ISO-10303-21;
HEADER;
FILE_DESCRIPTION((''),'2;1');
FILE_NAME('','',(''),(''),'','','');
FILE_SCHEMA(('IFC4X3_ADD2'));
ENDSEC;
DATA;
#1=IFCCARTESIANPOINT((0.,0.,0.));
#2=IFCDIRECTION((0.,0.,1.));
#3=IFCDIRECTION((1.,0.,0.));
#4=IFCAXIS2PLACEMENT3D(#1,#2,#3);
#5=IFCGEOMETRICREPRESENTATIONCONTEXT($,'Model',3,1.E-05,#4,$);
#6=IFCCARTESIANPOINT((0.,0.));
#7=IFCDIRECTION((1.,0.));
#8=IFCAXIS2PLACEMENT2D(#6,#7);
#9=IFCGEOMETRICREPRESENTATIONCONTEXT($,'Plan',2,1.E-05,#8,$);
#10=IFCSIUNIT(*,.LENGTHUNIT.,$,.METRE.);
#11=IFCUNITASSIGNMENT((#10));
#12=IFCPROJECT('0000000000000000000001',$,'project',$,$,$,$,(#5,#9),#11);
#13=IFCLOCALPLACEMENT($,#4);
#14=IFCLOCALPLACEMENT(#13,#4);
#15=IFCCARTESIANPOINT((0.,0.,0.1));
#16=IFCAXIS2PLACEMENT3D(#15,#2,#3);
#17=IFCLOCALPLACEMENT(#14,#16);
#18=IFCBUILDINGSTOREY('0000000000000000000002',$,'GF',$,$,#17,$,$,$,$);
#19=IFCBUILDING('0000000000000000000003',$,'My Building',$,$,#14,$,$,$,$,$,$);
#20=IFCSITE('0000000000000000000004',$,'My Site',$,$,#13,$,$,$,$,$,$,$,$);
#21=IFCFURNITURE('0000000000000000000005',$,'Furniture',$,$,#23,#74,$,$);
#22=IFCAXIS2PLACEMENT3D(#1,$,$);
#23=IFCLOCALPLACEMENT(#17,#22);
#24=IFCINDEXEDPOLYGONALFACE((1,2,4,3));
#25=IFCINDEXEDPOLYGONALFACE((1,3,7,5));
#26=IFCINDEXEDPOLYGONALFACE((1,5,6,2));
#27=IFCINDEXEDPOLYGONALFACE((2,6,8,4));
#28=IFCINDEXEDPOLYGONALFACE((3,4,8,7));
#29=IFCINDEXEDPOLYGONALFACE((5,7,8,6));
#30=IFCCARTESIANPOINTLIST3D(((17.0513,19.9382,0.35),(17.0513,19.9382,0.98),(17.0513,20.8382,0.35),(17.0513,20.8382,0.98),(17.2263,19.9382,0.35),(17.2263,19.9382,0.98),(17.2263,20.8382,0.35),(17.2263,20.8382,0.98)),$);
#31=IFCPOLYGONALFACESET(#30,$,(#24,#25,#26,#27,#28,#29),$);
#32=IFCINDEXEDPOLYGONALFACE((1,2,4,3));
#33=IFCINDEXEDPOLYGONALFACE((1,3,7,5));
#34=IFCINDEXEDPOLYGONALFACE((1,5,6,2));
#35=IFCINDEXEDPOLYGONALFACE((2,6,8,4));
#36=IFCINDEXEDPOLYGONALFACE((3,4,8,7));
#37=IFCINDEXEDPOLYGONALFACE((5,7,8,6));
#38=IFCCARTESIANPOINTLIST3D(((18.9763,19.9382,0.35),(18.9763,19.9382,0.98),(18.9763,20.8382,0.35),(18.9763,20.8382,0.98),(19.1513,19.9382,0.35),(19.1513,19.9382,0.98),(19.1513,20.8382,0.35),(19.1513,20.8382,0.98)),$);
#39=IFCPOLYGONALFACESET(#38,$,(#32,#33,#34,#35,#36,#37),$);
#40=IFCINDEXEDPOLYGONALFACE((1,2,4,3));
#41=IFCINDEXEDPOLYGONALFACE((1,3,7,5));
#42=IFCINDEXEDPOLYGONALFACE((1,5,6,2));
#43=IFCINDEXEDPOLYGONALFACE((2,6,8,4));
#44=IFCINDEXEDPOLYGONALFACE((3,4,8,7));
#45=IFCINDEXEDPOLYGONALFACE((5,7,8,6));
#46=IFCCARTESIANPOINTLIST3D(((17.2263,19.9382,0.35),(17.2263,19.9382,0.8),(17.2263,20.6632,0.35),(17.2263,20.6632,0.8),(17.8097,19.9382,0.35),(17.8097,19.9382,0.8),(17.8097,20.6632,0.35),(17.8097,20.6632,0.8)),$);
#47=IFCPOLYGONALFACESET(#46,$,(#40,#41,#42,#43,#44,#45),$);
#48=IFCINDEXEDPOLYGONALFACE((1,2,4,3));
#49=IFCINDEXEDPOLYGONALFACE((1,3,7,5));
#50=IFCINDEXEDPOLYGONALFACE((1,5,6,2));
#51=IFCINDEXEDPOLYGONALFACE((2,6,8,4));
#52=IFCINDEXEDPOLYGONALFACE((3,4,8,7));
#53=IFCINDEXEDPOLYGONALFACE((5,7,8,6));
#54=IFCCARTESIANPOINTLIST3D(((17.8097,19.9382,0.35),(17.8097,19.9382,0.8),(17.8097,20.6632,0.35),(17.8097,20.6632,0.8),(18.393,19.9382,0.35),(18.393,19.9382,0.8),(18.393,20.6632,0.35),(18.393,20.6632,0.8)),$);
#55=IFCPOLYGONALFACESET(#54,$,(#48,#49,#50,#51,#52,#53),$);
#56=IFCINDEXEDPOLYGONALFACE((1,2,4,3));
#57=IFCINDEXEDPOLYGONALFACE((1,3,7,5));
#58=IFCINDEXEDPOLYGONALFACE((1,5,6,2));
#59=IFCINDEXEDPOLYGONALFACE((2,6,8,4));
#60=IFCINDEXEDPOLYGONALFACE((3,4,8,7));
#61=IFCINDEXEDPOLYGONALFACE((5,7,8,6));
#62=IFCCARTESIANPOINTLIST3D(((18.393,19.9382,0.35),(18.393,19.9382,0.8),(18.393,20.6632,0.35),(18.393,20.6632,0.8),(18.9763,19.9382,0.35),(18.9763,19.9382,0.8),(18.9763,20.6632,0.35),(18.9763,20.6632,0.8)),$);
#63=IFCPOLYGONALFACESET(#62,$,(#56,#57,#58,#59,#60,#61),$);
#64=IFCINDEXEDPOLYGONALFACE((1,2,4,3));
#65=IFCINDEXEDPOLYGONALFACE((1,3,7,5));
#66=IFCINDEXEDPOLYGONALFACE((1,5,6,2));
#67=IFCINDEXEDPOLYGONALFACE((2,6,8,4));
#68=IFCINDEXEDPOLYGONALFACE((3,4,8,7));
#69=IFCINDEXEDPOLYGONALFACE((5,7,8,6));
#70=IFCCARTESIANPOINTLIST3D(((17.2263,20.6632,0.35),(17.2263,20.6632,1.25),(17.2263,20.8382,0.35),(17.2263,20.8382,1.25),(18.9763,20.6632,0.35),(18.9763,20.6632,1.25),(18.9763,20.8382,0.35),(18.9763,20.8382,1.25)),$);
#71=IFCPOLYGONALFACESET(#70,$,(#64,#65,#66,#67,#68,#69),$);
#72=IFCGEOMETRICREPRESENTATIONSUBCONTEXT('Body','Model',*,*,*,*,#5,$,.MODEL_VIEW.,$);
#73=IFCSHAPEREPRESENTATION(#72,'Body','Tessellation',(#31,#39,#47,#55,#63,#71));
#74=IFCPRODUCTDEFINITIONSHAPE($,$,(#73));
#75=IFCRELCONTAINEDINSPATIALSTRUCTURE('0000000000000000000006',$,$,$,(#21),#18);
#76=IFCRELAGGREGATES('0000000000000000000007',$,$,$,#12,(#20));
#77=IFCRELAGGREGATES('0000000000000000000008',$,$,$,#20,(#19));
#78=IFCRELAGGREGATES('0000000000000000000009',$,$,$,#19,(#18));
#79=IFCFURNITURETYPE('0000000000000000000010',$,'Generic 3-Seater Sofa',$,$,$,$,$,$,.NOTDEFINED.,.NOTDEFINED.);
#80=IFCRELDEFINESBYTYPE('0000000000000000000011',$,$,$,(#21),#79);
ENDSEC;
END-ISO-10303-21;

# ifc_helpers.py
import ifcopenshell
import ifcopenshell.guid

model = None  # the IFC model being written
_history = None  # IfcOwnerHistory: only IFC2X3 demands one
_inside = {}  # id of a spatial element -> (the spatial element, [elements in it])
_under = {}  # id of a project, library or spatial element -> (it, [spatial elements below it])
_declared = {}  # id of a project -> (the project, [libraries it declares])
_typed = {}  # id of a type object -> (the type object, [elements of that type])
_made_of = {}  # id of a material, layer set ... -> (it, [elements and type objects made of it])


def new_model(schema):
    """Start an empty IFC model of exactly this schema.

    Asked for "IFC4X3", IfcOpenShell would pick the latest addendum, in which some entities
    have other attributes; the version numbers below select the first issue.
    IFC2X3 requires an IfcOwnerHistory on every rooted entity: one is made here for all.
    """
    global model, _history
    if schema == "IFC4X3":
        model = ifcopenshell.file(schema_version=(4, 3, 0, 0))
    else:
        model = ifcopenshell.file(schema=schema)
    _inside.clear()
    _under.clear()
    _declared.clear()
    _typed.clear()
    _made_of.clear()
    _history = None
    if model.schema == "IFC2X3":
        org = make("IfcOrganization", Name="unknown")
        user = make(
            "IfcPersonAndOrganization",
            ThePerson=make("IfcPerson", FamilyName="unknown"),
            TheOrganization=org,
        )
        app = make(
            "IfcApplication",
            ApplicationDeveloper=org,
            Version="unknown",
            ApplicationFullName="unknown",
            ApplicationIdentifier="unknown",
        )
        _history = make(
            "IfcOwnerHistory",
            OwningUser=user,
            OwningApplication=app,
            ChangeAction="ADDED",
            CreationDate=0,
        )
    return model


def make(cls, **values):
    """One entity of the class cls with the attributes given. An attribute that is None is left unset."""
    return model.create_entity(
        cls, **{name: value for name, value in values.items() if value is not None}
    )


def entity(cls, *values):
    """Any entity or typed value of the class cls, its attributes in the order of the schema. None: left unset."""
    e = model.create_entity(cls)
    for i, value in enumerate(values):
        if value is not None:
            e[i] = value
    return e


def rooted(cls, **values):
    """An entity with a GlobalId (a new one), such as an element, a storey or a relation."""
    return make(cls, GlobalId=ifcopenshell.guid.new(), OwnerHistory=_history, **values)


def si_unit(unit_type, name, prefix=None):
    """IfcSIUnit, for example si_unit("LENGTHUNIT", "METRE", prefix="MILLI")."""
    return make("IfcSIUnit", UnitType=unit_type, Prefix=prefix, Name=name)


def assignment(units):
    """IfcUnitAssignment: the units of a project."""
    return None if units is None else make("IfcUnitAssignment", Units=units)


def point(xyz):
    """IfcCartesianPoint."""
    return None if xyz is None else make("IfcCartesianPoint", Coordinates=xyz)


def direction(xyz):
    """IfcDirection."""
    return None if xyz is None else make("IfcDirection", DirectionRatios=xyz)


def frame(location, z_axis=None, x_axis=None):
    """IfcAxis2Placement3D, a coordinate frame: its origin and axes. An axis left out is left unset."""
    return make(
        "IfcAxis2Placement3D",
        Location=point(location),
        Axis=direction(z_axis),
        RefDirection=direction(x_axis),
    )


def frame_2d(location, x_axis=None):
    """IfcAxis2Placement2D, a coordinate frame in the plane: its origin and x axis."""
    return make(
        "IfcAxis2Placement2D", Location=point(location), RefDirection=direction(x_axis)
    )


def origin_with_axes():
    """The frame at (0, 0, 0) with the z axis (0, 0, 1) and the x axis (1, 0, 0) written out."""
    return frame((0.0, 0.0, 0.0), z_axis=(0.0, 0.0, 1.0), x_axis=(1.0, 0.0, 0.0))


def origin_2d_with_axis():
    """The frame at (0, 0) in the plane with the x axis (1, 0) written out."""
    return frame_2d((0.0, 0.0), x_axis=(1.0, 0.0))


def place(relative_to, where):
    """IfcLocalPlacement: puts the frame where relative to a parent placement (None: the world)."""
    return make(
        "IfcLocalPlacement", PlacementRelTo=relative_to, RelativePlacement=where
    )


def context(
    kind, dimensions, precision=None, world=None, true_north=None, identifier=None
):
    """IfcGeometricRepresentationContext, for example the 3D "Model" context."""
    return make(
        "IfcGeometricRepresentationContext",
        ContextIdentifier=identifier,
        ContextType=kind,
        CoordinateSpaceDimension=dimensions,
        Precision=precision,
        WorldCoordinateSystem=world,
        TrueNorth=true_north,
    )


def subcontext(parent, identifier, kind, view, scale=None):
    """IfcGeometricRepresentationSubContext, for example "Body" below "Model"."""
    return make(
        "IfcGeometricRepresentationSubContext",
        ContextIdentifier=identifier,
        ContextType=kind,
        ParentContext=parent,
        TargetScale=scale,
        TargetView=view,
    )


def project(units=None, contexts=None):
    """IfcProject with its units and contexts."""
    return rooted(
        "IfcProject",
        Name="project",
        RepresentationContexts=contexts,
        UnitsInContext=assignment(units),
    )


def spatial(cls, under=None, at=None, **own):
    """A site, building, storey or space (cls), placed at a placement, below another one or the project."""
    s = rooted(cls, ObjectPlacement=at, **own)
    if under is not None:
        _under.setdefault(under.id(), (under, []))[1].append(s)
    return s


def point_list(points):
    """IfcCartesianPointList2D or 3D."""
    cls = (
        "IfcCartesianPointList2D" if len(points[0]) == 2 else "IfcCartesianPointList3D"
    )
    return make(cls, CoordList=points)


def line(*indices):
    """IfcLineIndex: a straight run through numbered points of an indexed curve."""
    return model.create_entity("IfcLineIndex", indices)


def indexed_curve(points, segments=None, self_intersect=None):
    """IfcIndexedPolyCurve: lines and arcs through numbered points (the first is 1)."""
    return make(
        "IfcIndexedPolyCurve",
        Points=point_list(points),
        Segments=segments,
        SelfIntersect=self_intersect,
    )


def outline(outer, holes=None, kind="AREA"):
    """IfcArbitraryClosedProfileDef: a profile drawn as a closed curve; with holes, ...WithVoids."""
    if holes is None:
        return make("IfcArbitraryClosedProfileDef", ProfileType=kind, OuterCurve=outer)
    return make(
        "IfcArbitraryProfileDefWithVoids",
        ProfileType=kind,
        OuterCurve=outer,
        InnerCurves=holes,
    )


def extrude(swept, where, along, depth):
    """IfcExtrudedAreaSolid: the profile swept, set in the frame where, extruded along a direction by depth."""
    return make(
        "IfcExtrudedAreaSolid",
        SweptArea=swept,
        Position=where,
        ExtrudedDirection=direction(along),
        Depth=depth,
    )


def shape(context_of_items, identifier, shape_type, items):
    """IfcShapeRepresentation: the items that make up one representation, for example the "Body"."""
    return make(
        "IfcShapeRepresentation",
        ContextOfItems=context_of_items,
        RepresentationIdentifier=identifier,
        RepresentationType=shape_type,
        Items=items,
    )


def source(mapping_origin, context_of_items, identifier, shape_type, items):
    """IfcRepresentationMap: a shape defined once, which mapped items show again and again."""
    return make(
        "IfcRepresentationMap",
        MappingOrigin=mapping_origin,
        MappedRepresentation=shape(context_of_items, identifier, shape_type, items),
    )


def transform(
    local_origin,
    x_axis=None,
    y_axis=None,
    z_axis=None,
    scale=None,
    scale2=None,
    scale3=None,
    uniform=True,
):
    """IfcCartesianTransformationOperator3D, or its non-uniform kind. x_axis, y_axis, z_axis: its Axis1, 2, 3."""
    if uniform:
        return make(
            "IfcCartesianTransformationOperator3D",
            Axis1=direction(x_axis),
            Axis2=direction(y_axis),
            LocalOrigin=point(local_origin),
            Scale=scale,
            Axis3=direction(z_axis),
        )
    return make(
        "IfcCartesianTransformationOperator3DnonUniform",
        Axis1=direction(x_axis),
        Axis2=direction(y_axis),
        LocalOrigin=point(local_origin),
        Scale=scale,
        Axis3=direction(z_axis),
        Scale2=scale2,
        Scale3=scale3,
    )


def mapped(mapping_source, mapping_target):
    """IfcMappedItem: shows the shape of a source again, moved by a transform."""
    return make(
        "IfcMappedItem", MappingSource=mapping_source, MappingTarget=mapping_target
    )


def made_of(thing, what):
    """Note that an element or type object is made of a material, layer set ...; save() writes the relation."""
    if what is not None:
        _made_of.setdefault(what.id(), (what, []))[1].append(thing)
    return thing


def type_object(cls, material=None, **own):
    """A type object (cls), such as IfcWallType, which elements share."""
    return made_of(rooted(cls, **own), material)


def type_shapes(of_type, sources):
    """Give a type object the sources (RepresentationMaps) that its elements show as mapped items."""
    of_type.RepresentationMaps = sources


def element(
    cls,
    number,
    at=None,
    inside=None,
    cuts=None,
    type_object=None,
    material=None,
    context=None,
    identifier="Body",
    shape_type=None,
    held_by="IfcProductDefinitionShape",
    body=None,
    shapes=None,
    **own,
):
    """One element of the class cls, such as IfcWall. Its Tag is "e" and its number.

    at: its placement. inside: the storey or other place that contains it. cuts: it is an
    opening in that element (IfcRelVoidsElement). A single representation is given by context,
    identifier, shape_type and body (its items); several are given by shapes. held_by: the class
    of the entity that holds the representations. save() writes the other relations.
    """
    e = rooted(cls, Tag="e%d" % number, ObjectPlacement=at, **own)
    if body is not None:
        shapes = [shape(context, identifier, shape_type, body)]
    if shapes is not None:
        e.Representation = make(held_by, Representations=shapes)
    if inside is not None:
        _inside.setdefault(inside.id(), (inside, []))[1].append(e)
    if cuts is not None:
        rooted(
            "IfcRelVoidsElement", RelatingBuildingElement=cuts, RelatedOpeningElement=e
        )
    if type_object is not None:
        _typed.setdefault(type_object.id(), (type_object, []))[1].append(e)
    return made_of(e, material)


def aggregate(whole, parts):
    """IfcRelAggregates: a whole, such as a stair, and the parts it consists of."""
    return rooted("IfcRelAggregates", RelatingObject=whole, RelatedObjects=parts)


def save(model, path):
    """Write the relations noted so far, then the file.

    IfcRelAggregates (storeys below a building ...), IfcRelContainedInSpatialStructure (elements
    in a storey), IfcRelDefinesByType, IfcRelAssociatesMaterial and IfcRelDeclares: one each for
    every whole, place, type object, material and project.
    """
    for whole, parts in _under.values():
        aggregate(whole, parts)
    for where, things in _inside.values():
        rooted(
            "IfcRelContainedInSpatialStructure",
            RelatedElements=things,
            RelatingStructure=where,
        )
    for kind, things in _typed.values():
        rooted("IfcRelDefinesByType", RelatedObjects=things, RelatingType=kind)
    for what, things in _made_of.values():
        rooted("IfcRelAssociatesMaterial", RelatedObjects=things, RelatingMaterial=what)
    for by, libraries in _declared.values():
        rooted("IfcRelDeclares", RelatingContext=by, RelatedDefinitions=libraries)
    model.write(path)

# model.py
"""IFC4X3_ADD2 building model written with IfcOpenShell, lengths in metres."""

from ifc_helpers import new_model, entity, si_unit, frame, origin_with_axes, origin_2d_with_axis, place, context, subcontext, project, spatial, line, indexed_curve, outline, extrude, shape, source, transform, mapped, type_object, type_shapes, element, save


model = new_model("IFC4X3_ADD2")

# Units and contexts
model_context = context("Model", 3, precision=1e-05, world=origin_with_axes())
plan_context = context("Plan", 2, precision=1e-05, world=origin_2d_with_axis())
body_context_1 = subcontext(model_context, "Body", "Model", "MODEL_VIEW")
body_context_2 = subcontext(plan_context, "Body", "Plan", "PLAN_VIEW")
ifc_project = project(units=[si_unit("LENGTHUNIT", "METRE")], contexts=[model_context, plan_context])

# Site, building, storey
site_placement = place(None, origin_with_axes())
site = spatial("IfcSite", under=ifc_project, at=site_placement, Name="My Site")
building_placement = place(site_placement, origin_with_axes())
building = spatial("IfcBuilding", under=site, at=building_placement, Name="My Building")
storey_placement = place(building_placement, frame((0.0, 0.0, 0.1), z_axis=(0.0, 0.0, 1.0), x_axis=(1.0, 0.0, 0.0)))
storey = spatial("IfcBuildingStorey", under=building, at=storey_placement, Name="GF")

# Furniture
furniture_type_1 = type_object("IfcFurnitureType", Name="Generic 3-Seater Sofa", AssemblyPlace="NOTDEFINED", PredefinedType="NOTDEFINED")
shared_shape_1 = source(origin_with_axes(), body_context_1, "Body", "SweptSolid", [
    extrude(outline(indexed_curve([(0.0, 0.0), (0.175, 0.0), (0.175, 0.9), (0.0, 0.9)], segments=[line(4, 1), line(1, 2), line(2, 3), line(3, 4)], self_intersect=False)), frame((-1.05, -0.9, 0.0), z_axis=(0.0, 0.0, 1.0), x_axis=(1.0, 0.0, 0.0)), (0.0, 0.0, 1.0), 0.63),
    extrude(outline(indexed_curve([(0.0, 0.0), (0.175, 0.0), (0.175, 0.9), (0.0, 0.9)], segments=[line(1, 2, 3, 4, 1)])), frame((0.875, -0.9, 0.0), z_axis=(0.0, 0.0, 1.0), x_axis=(1.0, 0.0, 0.0)), (0.0, 0.0, 1.0), 0.63),
    extrude(outline(indexed_curve([(0.175, 0.0), (0.7583, 0.0), (0.7583, 0.725), (0.175, 0.725)], segments=[line(1, 2, 3, 4, 1)])), frame((-1.05, -0.9, 0.0), z_axis=(0.0, 0.0, 1.0), x_axis=(1.0, 0.0, 0.0)), (0.0, 0.0, 1.0), 0.45),
    extrude(outline(indexed_curve([(0.7583, 0.0), (1.3417, 0.0), (1.3417, 0.725), (0.7583, 0.725)], segments=[line(1, 2, 3, 4, 1)])), frame((-1.05, -0.9, 0.0), z_axis=(0.0, 0.0, 1.0), x_axis=(1.0, 0.0, 0.0)), (0.0, 0.0, 1.0), 0.45),
    extrude(outline(indexed_curve([(1.3417, 0.0), (1.925, 0.0), (1.925, 0.725), (1.3417, 0.725)], segments=[line(1, 2, 3, 4, 1)])), frame((-1.05, -0.9, 0.0), z_axis=(0.0, 0.0, 1.0), x_axis=(1.0, 0.0, 0.0)), (0.0, 0.0, 1.0), 0.45),
    extrude(outline(indexed_curve([(0.175, 0.725), (1.925, 0.725), (1.925, 0.9), (0.175, 0.9)], segments=[line(1, 2, 3, 4, 1)])), frame((-1.05, -0.9, 0.0), z_axis=(0.0, 0.0, 1.0), x_axis=(1.0, 0.0, 0.0)), (0.0, 0.0, 1.0), 0.9),
])
shared_shape_2 = source(origin_with_axes(), body_context_2, "Body", "Annotation2D", [
    entity("IfcGeometricCurveSet", [entity("IfcIndexedPolyCurve", entity("IfcCartesianPointList2D", [[0.2917, -0.175], [0.2917, -0.9], [0.875, -0.9], [0.875, -0.175], [-0.875, -0.175], [-0.875, 0.0], [0.875, 0.0], [1.05, 0.0], [1.05, -0.9], [0.875, -0.9], [0.875, 0.0], [0.875, -0.175], [0.2917, -0.175], [-0.2917, -0.175], [-0.2917, -0.9], [-0.875, -0.9], [-0.875, 0.0], [-1.05, 0.0], [-1.05, -0.9], [-0.875, -0.9], [-0.875, -0.175], [-0.2917, -0.175]])), entity("IfcIndexedPolyCurve", entity("IfcCartesianPointList2D", [[0.2917, -0.9], [-0.2917, -0.9]]))]),
])
type_shapes(furniture_type_1, [shared_shape_1, shared_shape_2])
furniture_1_placement = place(storey_placement, frame((18.1013, 20.8382, 0.35), z_axis=(0.0, 0.0, 1.0), x_axis=(1.0, 0.0, 0.0)))
element("IfcFurniture", 1, at=furniture_1_placement, inside=storey, type_object=furniture_type_1, Name="Furniture", shapes=[
    shape(body_context_1, "Body", "MappedRepresentation", [mapped(shared_shape_1, transform((0.0, 0.0, 0.0), x_axis=(1.0, 0.0, 0.0), y_axis=(0.0, 1.0, 0.0), z_axis=(0.0, 0.0, 1.0), scale=1.0))]),
    shape(body_context_2, "Body", "MappedRepresentation", [mapped(shared_shape_2, transform((0.0, 0.0, 0.0), x_axis=(1.0, 0.0, 0.0), y_axis=(0.0, 1.0, 0.0), z_axis=(0.0, 0.0, 1.0), scale=1.0))]),
])

save(model, "model.ifc")
